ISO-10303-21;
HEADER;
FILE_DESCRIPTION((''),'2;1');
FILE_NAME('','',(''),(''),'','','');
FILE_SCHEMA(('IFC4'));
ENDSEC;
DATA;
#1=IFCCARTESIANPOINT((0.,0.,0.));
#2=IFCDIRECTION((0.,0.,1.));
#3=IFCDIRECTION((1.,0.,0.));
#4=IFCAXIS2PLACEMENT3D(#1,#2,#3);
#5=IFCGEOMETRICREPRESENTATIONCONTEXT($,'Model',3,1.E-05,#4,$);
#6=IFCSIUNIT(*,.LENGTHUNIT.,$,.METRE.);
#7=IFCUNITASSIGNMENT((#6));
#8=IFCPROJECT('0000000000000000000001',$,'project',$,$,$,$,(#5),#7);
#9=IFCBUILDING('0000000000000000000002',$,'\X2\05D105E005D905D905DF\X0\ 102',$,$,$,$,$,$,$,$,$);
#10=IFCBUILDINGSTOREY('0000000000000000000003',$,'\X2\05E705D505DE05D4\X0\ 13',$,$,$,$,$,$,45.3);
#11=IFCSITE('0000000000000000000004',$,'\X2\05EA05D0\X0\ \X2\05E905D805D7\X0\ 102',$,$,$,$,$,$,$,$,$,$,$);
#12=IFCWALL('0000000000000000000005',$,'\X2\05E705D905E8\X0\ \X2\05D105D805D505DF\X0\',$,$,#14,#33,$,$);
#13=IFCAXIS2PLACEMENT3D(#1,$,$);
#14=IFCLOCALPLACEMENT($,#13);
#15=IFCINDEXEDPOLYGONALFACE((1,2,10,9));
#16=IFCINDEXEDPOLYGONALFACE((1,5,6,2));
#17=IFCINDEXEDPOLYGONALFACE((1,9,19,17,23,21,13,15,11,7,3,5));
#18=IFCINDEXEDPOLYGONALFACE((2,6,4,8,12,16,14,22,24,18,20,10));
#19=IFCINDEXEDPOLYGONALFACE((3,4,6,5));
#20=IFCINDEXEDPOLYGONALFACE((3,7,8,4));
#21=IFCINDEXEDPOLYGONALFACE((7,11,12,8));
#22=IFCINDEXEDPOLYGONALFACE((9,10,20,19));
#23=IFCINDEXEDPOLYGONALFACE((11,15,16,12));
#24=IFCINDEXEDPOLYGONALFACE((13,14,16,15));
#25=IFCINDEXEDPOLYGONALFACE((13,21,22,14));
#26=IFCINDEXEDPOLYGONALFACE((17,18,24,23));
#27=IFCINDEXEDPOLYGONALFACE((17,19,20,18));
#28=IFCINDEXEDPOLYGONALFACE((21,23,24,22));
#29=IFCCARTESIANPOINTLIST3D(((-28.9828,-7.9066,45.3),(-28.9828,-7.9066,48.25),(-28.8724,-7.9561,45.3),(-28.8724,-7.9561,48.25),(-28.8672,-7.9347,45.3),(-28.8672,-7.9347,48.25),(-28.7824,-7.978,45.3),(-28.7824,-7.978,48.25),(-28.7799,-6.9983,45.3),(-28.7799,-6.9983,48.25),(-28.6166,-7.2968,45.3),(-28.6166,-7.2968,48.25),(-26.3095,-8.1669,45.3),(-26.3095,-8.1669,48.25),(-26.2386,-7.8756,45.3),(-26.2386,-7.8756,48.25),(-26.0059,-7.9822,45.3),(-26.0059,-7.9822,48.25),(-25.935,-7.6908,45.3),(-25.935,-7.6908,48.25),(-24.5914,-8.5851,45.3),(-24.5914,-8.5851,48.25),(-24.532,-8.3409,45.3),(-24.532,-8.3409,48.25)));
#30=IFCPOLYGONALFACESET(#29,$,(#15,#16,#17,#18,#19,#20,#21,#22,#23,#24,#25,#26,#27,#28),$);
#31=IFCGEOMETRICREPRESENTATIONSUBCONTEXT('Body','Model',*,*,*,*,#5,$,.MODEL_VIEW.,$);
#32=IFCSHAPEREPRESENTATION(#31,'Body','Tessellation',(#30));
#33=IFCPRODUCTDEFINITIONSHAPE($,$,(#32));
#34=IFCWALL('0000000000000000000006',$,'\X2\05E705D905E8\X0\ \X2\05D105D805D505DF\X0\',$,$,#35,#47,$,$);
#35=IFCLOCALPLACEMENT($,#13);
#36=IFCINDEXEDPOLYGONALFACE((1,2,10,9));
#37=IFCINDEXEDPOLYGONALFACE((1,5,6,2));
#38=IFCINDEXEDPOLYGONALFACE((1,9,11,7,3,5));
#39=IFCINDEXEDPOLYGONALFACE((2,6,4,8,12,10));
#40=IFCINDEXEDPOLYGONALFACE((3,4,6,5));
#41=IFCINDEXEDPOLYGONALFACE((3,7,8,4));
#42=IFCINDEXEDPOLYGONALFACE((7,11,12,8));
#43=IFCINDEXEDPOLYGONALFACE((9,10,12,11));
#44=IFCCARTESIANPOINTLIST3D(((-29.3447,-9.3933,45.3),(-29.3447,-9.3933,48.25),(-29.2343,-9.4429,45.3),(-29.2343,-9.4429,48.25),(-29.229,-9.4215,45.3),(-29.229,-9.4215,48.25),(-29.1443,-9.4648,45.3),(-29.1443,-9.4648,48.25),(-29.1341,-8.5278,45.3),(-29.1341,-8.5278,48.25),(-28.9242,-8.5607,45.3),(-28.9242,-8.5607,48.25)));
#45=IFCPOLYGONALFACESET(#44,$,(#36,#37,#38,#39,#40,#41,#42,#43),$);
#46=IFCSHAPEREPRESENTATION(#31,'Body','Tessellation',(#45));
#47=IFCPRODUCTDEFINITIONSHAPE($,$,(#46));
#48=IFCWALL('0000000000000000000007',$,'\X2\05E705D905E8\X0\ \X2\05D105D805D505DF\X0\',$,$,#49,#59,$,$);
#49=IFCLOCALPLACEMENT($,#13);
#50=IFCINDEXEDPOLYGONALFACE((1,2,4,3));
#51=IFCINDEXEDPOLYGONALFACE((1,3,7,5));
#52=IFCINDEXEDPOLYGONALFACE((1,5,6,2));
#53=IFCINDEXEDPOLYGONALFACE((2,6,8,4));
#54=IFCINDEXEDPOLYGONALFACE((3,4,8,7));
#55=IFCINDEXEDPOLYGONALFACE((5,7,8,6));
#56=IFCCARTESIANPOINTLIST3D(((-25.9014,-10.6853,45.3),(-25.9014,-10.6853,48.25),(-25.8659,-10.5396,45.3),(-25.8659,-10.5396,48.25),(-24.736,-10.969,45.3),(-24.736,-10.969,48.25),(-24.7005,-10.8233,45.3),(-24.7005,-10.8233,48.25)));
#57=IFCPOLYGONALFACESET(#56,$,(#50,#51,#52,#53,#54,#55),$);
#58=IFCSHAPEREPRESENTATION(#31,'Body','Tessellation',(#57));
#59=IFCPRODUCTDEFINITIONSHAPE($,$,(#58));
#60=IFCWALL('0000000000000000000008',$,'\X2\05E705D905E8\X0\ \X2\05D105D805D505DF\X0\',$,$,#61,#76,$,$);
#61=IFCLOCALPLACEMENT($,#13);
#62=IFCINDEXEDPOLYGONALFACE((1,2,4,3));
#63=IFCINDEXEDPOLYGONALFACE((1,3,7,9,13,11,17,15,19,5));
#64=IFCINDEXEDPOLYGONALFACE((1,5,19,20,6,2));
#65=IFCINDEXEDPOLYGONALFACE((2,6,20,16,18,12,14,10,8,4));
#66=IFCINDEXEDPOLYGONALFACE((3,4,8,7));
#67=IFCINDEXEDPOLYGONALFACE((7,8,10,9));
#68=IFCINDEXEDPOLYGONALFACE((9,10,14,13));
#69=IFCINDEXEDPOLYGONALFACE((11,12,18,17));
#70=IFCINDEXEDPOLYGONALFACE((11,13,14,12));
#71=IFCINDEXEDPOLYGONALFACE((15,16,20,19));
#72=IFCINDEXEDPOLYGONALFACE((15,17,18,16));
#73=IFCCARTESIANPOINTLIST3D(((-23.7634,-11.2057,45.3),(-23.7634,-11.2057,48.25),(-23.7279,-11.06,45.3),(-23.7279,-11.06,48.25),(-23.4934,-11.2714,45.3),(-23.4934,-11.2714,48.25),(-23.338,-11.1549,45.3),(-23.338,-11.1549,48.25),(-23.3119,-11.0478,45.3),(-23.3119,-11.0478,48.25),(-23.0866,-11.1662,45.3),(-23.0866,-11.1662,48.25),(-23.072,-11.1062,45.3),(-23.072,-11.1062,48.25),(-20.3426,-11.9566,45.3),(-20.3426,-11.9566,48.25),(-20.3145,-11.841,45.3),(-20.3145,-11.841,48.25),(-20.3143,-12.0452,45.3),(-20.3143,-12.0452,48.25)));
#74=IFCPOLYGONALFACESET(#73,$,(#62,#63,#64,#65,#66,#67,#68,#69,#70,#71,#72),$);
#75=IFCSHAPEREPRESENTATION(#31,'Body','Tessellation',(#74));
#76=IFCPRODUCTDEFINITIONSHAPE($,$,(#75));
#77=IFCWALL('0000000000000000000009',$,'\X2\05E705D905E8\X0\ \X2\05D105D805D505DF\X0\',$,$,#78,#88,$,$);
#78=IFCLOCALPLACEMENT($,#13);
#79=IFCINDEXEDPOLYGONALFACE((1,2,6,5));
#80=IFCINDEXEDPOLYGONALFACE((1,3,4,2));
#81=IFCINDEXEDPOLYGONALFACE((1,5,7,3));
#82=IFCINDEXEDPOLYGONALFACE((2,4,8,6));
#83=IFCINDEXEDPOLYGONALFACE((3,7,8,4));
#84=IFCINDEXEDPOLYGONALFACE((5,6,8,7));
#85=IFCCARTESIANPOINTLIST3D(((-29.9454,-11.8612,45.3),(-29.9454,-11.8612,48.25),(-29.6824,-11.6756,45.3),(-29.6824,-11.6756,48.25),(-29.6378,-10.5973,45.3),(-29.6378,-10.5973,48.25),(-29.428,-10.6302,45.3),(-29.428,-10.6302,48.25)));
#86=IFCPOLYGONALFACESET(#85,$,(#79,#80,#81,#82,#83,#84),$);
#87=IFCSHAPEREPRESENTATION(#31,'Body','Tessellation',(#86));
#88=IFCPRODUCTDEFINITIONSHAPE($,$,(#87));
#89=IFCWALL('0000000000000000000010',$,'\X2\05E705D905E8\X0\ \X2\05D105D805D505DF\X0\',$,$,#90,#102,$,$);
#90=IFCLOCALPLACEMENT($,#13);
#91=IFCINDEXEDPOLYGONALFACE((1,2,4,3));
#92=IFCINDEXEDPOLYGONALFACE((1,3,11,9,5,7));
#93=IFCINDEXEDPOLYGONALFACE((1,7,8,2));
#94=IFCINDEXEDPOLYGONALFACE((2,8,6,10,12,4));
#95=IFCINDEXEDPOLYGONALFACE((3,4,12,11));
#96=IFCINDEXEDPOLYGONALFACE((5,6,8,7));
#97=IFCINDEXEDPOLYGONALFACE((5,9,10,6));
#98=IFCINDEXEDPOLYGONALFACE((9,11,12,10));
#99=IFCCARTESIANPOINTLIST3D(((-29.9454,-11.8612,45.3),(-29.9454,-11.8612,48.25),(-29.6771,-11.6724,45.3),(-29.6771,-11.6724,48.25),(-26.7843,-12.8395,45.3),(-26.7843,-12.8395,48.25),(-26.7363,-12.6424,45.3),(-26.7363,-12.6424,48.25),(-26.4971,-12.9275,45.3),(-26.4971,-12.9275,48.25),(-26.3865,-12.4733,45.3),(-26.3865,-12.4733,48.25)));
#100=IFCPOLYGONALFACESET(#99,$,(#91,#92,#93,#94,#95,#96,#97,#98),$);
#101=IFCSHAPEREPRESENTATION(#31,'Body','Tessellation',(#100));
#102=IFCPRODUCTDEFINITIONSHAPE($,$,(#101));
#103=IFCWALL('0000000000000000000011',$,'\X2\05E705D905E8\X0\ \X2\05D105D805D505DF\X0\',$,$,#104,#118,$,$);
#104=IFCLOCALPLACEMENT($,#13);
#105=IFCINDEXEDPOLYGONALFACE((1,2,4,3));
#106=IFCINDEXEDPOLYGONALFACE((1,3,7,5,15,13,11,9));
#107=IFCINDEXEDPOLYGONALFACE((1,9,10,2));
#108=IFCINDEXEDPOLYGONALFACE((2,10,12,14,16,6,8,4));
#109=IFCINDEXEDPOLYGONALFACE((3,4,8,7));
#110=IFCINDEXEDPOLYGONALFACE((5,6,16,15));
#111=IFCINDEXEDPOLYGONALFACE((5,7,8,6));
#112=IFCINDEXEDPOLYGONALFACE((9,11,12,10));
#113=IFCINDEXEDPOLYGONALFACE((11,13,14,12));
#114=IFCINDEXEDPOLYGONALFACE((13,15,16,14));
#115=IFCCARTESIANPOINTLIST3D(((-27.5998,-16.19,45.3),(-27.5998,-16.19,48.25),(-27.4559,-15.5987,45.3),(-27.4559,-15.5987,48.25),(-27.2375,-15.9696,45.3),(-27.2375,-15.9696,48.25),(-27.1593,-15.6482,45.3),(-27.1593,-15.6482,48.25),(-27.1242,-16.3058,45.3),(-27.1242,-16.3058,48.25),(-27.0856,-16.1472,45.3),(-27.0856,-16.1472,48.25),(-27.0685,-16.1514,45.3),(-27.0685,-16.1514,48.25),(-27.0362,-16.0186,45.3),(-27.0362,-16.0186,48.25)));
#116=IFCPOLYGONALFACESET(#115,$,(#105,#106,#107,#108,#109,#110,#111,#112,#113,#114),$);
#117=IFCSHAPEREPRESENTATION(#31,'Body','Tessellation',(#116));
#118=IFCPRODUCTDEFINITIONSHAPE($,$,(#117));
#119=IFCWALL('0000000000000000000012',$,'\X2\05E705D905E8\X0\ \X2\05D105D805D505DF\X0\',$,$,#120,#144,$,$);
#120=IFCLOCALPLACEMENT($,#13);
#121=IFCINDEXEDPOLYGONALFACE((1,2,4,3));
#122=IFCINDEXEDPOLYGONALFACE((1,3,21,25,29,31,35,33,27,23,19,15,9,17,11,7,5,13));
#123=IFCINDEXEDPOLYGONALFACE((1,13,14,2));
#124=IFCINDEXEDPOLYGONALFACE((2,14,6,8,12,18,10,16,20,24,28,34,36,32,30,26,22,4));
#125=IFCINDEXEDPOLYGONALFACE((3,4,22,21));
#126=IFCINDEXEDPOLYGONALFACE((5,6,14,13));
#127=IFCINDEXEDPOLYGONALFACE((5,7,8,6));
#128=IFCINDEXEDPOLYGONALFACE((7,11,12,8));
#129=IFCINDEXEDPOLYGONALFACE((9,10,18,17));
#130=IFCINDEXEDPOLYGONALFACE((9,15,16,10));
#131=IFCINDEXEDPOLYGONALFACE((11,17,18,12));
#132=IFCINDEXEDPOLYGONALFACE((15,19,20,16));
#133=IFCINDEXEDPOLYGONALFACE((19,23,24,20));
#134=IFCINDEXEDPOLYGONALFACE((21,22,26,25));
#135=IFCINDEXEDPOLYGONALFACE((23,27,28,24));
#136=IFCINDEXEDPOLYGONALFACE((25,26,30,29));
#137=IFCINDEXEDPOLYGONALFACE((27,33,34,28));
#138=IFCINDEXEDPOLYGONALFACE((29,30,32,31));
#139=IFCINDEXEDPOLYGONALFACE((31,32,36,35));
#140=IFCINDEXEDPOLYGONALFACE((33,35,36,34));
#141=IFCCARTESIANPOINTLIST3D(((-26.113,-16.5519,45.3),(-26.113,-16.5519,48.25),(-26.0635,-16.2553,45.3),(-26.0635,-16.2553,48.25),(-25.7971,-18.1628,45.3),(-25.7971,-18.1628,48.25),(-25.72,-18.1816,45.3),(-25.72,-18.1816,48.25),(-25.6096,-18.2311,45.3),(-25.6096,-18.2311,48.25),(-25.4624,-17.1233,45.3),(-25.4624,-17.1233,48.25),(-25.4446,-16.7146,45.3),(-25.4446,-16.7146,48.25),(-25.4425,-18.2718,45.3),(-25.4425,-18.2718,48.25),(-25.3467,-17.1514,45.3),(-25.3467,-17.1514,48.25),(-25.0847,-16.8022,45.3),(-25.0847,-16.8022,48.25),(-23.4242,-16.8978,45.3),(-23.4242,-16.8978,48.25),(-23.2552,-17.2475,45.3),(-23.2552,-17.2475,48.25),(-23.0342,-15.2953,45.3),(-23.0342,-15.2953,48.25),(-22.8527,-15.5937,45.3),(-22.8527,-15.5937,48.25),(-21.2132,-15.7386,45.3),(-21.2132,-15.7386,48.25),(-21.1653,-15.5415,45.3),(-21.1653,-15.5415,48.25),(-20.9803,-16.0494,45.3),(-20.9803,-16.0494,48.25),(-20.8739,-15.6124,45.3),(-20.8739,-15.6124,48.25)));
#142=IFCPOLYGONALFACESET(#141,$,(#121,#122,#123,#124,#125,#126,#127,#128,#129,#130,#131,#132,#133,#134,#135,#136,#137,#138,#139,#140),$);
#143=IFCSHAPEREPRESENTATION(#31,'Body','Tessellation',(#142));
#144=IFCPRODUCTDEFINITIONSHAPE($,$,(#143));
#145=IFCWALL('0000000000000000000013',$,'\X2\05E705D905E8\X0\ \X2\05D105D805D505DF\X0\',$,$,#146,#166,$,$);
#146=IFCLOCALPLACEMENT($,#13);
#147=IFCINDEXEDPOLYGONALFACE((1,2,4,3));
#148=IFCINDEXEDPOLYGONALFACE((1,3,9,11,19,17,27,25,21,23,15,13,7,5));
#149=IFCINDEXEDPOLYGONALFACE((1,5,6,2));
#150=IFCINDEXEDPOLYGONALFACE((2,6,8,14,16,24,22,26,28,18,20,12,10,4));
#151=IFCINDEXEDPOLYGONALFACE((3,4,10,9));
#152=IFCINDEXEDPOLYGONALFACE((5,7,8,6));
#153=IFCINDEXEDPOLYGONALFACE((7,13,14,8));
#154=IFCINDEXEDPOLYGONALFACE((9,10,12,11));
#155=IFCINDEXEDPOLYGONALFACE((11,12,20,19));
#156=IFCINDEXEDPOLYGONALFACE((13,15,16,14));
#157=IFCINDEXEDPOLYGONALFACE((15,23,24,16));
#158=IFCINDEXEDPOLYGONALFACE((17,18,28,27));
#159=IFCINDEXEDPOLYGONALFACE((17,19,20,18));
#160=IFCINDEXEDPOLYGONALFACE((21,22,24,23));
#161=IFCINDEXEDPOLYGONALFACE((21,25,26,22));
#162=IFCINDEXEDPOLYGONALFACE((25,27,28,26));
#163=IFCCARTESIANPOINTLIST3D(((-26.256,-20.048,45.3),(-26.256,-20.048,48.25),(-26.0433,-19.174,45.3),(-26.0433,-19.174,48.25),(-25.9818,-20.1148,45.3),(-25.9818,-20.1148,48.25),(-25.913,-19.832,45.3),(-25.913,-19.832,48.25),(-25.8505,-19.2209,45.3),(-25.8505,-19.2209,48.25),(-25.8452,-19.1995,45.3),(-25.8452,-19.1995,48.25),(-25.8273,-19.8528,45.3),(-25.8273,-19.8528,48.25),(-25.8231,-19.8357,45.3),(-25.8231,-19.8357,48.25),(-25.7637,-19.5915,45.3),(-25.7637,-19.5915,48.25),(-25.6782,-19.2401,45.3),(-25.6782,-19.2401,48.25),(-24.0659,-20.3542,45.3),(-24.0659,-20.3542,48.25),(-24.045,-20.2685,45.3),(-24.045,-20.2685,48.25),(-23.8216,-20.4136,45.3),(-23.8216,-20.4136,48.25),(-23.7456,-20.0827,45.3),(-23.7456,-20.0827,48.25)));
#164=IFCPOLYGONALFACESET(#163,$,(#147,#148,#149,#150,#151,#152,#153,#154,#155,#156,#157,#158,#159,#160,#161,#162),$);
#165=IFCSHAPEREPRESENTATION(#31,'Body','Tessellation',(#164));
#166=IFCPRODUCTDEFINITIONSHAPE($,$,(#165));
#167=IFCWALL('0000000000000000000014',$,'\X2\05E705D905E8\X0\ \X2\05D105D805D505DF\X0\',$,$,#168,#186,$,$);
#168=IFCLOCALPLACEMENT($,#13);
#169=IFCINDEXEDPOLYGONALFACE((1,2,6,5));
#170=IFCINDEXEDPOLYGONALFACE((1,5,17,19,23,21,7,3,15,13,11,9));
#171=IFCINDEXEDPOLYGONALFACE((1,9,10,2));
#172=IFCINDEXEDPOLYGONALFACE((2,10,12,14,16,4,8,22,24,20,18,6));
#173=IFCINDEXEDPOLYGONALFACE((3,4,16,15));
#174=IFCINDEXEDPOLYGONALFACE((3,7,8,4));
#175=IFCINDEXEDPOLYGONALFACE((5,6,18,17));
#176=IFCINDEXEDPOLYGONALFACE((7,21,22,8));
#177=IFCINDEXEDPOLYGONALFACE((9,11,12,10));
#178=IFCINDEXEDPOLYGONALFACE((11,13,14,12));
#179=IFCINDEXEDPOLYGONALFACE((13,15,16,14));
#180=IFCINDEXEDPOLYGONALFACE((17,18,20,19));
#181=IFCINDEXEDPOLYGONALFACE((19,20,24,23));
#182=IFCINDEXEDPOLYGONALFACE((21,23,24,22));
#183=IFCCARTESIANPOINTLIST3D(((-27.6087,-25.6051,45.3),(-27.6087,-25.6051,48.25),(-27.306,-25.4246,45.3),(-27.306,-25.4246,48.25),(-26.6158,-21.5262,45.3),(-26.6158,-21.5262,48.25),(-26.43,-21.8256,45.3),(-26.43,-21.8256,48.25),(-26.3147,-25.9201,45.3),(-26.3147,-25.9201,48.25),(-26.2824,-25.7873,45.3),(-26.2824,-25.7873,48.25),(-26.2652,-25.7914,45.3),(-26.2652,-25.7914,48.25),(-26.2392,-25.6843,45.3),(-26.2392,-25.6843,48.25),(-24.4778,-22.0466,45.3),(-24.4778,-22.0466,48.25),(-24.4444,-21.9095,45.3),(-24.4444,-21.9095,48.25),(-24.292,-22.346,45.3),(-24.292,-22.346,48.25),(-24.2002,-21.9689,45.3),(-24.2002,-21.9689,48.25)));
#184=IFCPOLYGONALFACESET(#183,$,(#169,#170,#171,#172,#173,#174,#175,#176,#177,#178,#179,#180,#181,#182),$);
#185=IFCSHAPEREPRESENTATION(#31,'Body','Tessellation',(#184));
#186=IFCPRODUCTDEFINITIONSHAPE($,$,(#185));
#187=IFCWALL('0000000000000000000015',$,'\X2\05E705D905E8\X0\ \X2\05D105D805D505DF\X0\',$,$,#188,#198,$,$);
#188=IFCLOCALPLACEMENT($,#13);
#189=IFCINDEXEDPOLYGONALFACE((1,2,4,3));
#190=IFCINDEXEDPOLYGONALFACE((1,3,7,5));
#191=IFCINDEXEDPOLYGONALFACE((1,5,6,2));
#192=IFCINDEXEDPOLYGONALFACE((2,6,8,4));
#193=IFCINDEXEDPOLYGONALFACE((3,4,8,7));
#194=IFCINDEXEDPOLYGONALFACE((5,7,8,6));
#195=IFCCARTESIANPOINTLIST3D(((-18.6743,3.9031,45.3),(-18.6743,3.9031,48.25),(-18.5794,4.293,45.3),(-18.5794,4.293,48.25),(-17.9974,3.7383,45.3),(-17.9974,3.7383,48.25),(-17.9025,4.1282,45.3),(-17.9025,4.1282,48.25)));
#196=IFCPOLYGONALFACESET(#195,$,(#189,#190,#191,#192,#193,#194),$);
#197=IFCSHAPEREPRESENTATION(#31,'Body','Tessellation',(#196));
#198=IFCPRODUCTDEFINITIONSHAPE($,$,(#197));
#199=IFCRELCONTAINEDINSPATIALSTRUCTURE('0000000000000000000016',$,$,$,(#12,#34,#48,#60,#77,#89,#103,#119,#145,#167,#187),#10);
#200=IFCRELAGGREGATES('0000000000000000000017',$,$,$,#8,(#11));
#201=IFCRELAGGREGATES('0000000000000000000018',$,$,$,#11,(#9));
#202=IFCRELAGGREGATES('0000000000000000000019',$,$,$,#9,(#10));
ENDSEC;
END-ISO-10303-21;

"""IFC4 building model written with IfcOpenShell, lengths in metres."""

from ifc_helpers import new_model, si_unit, frame, origin_with_axes, context, subcontext, project, spatial, polyline, outline, extrude, element, save


model = new_model("IFC4")

# Units and contexts
model_context = context("Model", 3, precision=1e-05, world=origin_with_axes())
body_context = subcontext(model_context, "Body", "Model", "MODEL_VIEW")
ifc_project = project(units=[si_unit("LENGTHUNIT", "METRE")], contexts=[model_context])

# Site, building, storey
site = spatial("IfcSite", under=ifc_project, Name="תא שטח 102")
building = spatial("IfcBuilding", under=site, Name="בניין 102")
storey = spatial("IfcBuildingStorey", under=building, Name="קומה 13", Elevation=45.3)

# Walls
element("IfcWall", 1, inside=storey, Name="קיר בטון", context=body_context, shape_type="SweptSolid", body=[
    extrude(outline(polyline([(-28.8672, -7.9347), (-28.8724, -7.9561), (-28.7824, -7.978), (-28.6166, -7.2968), (-26.2386, -7.8756), (-26.3095, -8.1669), (-24.5914, -8.5851), (-24.532, -8.3409), (-26.0059, -7.9822), (-25.935, -7.6908), (-28.7799, -6.9983), (-28.9828, -7.9066), (-28.8672, -7.9347)])), frame((0.0, 0.0, 45.3)), (0.0, 0.0, 1.0), 2.95),
])
element("IfcWall", 2, inside=storey, Name="קיר בטון", context=body_context, shape_type="SweptSolid", body=[
    extrude(outline(polyline([(-29.229, -9.4215), (-29.2343, -9.4429), (-29.1443, -9.4648), (-28.9242, -8.5607), (-29.1341, -8.5278), (-29.3447, -9.3933), (-29.229, -9.4215)])), frame((0.0, 0.0, 45.3)), (0.0, 0.0, 1.0), 2.95),
])
element("IfcWall", 3, inside=storey, Name="קיר בטון", context=body_context, shape_type="SweptSolid", body=[
    extrude(outline(polyline([(-25.8659, -10.5396), (-25.9014, -10.6853), (-24.736, -10.969), (-24.7005, -10.8233), (-25.8659, -10.5396)])), frame((0.0, 0.0, 45.3)), (0.0, 0.0, 1.0), 2.95),
])
element("IfcWall", 4, inside=storey, Name="קיר בטון", context=body_context, shape_type="SweptSolid", body=[
    extrude(outline(polyline([(-23.7634, -11.2057), (-23.4934, -11.2714), (-20.3143, -12.0452), (-20.3426, -11.9566), (-20.3145, -11.841), (-23.0866, -11.1662), (-23.072, -11.1062), (-23.3119, -11.0478), (-23.338, -11.1549), (-23.7279, -11.06), (-23.7634, -11.2057)])), frame((0.0, 0.0, 45.3)), (0.0, 0.0, 1.0), 2.95),
])
element("IfcWall", 5, inside=storey, Name="קיר בטון", context=body_context, shape_type="SweptSolid", body=[
    extrude(outline(polyline([(-29.9454, -11.8612), (-29.6824, -11.6756), (-29.428, -10.6302), (-29.6378, -10.5973), (-29.9454, -11.8612)])), frame((0.0, 0.0, 45.3)), (0.0, 0.0, 1.0), 2.95),
])
element("IfcWall", 6, inside=storey, Name="קיר בטון", context=body_context, shape_type="SweptSolid", body=[
    extrude(outline(polyline([(-26.7843, -12.8395), (-26.4971, -12.9275), (-26.3865, -12.4733), (-29.6771, -11.6724), (-29.9454, -11.8612), (-26.7363, -12.6424), (-26.7843, -12.8395)])), frame((0.0, 0.0, 45.3)), (0.0, 0.0, 1.0), 2.95),
])
element("IfcWall", 7, inside=storey, Name="קיר בטון", context=body_context, shape_type="SweptSolid", body=[
    extrude(outline(polyline([(-27.0856, -16.1472), (-27.0685, -16.1514), (-27.0362, -16.0186), (-27.2375, -15.9696), (-27.1593, -15.6482), (-27.4559, -15.5987), (-27.5998, -16.19), (-27.1242, -16.3058), (-27.0856, -16.1472)])), frame((0.0, 0.0, 45.3)), (0.0, 0.0, 1.0), 2.95),
])
element("IfcWall", 8, inside=storey, Name="קיר בטון", context=body_context, shape_type="SweptSolid", body=[
    extrude(outline(polyline([(-25.6096, -18.2311), (-25.4425, -18.2718), (-25.0847, -16.8022), (-23.2552, -17.2475), (-22.8527, -15.5937), (-20.9803, -16.0494), (-20.8739, -15.6124), (-21.1653, -15.5415), (-21.2132, -15.7386), (-23.0342, -15.2953), (-23.4242, -16.8978), (-26.0635, -16.2553), (-26.113, -16.5519), (-25.4446, -16.7146), (-25.7971, -18.1628), (-25.72, -18.1816), (-25.4624, -17.1233), (-25.3467, -17.1514), (-25.6096, -18.2311)])), frame((0.0, 0.0, 45.3)), (0.0, 0.0, 1.0), 2.95),
])
element("IfcWall", 9, inside=storey, Name="קיר בטון", context=body_context, shape_type="SweptSolid", body=[
    extrude(outline(polyline([(-25.8505, -19.2209), (-26.0433, -19.174), (-26.256, -20.048), (-25.9818, -20.1148), (-25.913, -19.832), (-25.8273, -19.8528), (-25.8231, -19.8357), (-24.045, -20.2685), (-24.0659, -20.3542), (-23.8216, -20.4136), (-23.7456, -20.0827), (-25.7637, -19.5915), (-25.6782, -19.2401), (-25.8452, -19.1995), (-25.8505, -19.2209)])), frame((0.0, 0.0, 45.3)), (0.0, 0.0, 1.0), 2.95),
])
element("IfcWall", 10, inside=storey, Name="קיר בטון", context=body_context, shape_type="SweptSolid", body=[
    extrude(outline(polyline([(-27.6087, -25.6051), (-26.3147, -25.9201), (-26.2824, -25.7873), (-26.2652, -25.7914), (-26.2392, -25.6843), (-27.306, -25.4246), (-26.43, -21.8256), (-24.292, -22.346), (-24.2002, -21.9689), (-24.4444, -21.9095), (-24.4778, -22.0466), (-26.6158, -21.5262), (-27.6087, -25.6051)])), frame((0.0, 0.0, 45.3)), (0.0, 0.0, 1.0), 2.95),
])
element("IfcWall", 11, inside=storey, Name="קיר בטון", context=body_context, shape_type="SweptSolid", body=[
    extrude(outline(polyline([(-17.9974, 3.7383), (-17.9025, 4.1282), (-18.5794, 4.293), (-18.6743, 3.9031), (-17.9974, 3.7383)])), frame((0.0, 0.0, 45.3)), (0.0, 0.0, 1.0), 2.95),
])

save(model, "model.ifc")
